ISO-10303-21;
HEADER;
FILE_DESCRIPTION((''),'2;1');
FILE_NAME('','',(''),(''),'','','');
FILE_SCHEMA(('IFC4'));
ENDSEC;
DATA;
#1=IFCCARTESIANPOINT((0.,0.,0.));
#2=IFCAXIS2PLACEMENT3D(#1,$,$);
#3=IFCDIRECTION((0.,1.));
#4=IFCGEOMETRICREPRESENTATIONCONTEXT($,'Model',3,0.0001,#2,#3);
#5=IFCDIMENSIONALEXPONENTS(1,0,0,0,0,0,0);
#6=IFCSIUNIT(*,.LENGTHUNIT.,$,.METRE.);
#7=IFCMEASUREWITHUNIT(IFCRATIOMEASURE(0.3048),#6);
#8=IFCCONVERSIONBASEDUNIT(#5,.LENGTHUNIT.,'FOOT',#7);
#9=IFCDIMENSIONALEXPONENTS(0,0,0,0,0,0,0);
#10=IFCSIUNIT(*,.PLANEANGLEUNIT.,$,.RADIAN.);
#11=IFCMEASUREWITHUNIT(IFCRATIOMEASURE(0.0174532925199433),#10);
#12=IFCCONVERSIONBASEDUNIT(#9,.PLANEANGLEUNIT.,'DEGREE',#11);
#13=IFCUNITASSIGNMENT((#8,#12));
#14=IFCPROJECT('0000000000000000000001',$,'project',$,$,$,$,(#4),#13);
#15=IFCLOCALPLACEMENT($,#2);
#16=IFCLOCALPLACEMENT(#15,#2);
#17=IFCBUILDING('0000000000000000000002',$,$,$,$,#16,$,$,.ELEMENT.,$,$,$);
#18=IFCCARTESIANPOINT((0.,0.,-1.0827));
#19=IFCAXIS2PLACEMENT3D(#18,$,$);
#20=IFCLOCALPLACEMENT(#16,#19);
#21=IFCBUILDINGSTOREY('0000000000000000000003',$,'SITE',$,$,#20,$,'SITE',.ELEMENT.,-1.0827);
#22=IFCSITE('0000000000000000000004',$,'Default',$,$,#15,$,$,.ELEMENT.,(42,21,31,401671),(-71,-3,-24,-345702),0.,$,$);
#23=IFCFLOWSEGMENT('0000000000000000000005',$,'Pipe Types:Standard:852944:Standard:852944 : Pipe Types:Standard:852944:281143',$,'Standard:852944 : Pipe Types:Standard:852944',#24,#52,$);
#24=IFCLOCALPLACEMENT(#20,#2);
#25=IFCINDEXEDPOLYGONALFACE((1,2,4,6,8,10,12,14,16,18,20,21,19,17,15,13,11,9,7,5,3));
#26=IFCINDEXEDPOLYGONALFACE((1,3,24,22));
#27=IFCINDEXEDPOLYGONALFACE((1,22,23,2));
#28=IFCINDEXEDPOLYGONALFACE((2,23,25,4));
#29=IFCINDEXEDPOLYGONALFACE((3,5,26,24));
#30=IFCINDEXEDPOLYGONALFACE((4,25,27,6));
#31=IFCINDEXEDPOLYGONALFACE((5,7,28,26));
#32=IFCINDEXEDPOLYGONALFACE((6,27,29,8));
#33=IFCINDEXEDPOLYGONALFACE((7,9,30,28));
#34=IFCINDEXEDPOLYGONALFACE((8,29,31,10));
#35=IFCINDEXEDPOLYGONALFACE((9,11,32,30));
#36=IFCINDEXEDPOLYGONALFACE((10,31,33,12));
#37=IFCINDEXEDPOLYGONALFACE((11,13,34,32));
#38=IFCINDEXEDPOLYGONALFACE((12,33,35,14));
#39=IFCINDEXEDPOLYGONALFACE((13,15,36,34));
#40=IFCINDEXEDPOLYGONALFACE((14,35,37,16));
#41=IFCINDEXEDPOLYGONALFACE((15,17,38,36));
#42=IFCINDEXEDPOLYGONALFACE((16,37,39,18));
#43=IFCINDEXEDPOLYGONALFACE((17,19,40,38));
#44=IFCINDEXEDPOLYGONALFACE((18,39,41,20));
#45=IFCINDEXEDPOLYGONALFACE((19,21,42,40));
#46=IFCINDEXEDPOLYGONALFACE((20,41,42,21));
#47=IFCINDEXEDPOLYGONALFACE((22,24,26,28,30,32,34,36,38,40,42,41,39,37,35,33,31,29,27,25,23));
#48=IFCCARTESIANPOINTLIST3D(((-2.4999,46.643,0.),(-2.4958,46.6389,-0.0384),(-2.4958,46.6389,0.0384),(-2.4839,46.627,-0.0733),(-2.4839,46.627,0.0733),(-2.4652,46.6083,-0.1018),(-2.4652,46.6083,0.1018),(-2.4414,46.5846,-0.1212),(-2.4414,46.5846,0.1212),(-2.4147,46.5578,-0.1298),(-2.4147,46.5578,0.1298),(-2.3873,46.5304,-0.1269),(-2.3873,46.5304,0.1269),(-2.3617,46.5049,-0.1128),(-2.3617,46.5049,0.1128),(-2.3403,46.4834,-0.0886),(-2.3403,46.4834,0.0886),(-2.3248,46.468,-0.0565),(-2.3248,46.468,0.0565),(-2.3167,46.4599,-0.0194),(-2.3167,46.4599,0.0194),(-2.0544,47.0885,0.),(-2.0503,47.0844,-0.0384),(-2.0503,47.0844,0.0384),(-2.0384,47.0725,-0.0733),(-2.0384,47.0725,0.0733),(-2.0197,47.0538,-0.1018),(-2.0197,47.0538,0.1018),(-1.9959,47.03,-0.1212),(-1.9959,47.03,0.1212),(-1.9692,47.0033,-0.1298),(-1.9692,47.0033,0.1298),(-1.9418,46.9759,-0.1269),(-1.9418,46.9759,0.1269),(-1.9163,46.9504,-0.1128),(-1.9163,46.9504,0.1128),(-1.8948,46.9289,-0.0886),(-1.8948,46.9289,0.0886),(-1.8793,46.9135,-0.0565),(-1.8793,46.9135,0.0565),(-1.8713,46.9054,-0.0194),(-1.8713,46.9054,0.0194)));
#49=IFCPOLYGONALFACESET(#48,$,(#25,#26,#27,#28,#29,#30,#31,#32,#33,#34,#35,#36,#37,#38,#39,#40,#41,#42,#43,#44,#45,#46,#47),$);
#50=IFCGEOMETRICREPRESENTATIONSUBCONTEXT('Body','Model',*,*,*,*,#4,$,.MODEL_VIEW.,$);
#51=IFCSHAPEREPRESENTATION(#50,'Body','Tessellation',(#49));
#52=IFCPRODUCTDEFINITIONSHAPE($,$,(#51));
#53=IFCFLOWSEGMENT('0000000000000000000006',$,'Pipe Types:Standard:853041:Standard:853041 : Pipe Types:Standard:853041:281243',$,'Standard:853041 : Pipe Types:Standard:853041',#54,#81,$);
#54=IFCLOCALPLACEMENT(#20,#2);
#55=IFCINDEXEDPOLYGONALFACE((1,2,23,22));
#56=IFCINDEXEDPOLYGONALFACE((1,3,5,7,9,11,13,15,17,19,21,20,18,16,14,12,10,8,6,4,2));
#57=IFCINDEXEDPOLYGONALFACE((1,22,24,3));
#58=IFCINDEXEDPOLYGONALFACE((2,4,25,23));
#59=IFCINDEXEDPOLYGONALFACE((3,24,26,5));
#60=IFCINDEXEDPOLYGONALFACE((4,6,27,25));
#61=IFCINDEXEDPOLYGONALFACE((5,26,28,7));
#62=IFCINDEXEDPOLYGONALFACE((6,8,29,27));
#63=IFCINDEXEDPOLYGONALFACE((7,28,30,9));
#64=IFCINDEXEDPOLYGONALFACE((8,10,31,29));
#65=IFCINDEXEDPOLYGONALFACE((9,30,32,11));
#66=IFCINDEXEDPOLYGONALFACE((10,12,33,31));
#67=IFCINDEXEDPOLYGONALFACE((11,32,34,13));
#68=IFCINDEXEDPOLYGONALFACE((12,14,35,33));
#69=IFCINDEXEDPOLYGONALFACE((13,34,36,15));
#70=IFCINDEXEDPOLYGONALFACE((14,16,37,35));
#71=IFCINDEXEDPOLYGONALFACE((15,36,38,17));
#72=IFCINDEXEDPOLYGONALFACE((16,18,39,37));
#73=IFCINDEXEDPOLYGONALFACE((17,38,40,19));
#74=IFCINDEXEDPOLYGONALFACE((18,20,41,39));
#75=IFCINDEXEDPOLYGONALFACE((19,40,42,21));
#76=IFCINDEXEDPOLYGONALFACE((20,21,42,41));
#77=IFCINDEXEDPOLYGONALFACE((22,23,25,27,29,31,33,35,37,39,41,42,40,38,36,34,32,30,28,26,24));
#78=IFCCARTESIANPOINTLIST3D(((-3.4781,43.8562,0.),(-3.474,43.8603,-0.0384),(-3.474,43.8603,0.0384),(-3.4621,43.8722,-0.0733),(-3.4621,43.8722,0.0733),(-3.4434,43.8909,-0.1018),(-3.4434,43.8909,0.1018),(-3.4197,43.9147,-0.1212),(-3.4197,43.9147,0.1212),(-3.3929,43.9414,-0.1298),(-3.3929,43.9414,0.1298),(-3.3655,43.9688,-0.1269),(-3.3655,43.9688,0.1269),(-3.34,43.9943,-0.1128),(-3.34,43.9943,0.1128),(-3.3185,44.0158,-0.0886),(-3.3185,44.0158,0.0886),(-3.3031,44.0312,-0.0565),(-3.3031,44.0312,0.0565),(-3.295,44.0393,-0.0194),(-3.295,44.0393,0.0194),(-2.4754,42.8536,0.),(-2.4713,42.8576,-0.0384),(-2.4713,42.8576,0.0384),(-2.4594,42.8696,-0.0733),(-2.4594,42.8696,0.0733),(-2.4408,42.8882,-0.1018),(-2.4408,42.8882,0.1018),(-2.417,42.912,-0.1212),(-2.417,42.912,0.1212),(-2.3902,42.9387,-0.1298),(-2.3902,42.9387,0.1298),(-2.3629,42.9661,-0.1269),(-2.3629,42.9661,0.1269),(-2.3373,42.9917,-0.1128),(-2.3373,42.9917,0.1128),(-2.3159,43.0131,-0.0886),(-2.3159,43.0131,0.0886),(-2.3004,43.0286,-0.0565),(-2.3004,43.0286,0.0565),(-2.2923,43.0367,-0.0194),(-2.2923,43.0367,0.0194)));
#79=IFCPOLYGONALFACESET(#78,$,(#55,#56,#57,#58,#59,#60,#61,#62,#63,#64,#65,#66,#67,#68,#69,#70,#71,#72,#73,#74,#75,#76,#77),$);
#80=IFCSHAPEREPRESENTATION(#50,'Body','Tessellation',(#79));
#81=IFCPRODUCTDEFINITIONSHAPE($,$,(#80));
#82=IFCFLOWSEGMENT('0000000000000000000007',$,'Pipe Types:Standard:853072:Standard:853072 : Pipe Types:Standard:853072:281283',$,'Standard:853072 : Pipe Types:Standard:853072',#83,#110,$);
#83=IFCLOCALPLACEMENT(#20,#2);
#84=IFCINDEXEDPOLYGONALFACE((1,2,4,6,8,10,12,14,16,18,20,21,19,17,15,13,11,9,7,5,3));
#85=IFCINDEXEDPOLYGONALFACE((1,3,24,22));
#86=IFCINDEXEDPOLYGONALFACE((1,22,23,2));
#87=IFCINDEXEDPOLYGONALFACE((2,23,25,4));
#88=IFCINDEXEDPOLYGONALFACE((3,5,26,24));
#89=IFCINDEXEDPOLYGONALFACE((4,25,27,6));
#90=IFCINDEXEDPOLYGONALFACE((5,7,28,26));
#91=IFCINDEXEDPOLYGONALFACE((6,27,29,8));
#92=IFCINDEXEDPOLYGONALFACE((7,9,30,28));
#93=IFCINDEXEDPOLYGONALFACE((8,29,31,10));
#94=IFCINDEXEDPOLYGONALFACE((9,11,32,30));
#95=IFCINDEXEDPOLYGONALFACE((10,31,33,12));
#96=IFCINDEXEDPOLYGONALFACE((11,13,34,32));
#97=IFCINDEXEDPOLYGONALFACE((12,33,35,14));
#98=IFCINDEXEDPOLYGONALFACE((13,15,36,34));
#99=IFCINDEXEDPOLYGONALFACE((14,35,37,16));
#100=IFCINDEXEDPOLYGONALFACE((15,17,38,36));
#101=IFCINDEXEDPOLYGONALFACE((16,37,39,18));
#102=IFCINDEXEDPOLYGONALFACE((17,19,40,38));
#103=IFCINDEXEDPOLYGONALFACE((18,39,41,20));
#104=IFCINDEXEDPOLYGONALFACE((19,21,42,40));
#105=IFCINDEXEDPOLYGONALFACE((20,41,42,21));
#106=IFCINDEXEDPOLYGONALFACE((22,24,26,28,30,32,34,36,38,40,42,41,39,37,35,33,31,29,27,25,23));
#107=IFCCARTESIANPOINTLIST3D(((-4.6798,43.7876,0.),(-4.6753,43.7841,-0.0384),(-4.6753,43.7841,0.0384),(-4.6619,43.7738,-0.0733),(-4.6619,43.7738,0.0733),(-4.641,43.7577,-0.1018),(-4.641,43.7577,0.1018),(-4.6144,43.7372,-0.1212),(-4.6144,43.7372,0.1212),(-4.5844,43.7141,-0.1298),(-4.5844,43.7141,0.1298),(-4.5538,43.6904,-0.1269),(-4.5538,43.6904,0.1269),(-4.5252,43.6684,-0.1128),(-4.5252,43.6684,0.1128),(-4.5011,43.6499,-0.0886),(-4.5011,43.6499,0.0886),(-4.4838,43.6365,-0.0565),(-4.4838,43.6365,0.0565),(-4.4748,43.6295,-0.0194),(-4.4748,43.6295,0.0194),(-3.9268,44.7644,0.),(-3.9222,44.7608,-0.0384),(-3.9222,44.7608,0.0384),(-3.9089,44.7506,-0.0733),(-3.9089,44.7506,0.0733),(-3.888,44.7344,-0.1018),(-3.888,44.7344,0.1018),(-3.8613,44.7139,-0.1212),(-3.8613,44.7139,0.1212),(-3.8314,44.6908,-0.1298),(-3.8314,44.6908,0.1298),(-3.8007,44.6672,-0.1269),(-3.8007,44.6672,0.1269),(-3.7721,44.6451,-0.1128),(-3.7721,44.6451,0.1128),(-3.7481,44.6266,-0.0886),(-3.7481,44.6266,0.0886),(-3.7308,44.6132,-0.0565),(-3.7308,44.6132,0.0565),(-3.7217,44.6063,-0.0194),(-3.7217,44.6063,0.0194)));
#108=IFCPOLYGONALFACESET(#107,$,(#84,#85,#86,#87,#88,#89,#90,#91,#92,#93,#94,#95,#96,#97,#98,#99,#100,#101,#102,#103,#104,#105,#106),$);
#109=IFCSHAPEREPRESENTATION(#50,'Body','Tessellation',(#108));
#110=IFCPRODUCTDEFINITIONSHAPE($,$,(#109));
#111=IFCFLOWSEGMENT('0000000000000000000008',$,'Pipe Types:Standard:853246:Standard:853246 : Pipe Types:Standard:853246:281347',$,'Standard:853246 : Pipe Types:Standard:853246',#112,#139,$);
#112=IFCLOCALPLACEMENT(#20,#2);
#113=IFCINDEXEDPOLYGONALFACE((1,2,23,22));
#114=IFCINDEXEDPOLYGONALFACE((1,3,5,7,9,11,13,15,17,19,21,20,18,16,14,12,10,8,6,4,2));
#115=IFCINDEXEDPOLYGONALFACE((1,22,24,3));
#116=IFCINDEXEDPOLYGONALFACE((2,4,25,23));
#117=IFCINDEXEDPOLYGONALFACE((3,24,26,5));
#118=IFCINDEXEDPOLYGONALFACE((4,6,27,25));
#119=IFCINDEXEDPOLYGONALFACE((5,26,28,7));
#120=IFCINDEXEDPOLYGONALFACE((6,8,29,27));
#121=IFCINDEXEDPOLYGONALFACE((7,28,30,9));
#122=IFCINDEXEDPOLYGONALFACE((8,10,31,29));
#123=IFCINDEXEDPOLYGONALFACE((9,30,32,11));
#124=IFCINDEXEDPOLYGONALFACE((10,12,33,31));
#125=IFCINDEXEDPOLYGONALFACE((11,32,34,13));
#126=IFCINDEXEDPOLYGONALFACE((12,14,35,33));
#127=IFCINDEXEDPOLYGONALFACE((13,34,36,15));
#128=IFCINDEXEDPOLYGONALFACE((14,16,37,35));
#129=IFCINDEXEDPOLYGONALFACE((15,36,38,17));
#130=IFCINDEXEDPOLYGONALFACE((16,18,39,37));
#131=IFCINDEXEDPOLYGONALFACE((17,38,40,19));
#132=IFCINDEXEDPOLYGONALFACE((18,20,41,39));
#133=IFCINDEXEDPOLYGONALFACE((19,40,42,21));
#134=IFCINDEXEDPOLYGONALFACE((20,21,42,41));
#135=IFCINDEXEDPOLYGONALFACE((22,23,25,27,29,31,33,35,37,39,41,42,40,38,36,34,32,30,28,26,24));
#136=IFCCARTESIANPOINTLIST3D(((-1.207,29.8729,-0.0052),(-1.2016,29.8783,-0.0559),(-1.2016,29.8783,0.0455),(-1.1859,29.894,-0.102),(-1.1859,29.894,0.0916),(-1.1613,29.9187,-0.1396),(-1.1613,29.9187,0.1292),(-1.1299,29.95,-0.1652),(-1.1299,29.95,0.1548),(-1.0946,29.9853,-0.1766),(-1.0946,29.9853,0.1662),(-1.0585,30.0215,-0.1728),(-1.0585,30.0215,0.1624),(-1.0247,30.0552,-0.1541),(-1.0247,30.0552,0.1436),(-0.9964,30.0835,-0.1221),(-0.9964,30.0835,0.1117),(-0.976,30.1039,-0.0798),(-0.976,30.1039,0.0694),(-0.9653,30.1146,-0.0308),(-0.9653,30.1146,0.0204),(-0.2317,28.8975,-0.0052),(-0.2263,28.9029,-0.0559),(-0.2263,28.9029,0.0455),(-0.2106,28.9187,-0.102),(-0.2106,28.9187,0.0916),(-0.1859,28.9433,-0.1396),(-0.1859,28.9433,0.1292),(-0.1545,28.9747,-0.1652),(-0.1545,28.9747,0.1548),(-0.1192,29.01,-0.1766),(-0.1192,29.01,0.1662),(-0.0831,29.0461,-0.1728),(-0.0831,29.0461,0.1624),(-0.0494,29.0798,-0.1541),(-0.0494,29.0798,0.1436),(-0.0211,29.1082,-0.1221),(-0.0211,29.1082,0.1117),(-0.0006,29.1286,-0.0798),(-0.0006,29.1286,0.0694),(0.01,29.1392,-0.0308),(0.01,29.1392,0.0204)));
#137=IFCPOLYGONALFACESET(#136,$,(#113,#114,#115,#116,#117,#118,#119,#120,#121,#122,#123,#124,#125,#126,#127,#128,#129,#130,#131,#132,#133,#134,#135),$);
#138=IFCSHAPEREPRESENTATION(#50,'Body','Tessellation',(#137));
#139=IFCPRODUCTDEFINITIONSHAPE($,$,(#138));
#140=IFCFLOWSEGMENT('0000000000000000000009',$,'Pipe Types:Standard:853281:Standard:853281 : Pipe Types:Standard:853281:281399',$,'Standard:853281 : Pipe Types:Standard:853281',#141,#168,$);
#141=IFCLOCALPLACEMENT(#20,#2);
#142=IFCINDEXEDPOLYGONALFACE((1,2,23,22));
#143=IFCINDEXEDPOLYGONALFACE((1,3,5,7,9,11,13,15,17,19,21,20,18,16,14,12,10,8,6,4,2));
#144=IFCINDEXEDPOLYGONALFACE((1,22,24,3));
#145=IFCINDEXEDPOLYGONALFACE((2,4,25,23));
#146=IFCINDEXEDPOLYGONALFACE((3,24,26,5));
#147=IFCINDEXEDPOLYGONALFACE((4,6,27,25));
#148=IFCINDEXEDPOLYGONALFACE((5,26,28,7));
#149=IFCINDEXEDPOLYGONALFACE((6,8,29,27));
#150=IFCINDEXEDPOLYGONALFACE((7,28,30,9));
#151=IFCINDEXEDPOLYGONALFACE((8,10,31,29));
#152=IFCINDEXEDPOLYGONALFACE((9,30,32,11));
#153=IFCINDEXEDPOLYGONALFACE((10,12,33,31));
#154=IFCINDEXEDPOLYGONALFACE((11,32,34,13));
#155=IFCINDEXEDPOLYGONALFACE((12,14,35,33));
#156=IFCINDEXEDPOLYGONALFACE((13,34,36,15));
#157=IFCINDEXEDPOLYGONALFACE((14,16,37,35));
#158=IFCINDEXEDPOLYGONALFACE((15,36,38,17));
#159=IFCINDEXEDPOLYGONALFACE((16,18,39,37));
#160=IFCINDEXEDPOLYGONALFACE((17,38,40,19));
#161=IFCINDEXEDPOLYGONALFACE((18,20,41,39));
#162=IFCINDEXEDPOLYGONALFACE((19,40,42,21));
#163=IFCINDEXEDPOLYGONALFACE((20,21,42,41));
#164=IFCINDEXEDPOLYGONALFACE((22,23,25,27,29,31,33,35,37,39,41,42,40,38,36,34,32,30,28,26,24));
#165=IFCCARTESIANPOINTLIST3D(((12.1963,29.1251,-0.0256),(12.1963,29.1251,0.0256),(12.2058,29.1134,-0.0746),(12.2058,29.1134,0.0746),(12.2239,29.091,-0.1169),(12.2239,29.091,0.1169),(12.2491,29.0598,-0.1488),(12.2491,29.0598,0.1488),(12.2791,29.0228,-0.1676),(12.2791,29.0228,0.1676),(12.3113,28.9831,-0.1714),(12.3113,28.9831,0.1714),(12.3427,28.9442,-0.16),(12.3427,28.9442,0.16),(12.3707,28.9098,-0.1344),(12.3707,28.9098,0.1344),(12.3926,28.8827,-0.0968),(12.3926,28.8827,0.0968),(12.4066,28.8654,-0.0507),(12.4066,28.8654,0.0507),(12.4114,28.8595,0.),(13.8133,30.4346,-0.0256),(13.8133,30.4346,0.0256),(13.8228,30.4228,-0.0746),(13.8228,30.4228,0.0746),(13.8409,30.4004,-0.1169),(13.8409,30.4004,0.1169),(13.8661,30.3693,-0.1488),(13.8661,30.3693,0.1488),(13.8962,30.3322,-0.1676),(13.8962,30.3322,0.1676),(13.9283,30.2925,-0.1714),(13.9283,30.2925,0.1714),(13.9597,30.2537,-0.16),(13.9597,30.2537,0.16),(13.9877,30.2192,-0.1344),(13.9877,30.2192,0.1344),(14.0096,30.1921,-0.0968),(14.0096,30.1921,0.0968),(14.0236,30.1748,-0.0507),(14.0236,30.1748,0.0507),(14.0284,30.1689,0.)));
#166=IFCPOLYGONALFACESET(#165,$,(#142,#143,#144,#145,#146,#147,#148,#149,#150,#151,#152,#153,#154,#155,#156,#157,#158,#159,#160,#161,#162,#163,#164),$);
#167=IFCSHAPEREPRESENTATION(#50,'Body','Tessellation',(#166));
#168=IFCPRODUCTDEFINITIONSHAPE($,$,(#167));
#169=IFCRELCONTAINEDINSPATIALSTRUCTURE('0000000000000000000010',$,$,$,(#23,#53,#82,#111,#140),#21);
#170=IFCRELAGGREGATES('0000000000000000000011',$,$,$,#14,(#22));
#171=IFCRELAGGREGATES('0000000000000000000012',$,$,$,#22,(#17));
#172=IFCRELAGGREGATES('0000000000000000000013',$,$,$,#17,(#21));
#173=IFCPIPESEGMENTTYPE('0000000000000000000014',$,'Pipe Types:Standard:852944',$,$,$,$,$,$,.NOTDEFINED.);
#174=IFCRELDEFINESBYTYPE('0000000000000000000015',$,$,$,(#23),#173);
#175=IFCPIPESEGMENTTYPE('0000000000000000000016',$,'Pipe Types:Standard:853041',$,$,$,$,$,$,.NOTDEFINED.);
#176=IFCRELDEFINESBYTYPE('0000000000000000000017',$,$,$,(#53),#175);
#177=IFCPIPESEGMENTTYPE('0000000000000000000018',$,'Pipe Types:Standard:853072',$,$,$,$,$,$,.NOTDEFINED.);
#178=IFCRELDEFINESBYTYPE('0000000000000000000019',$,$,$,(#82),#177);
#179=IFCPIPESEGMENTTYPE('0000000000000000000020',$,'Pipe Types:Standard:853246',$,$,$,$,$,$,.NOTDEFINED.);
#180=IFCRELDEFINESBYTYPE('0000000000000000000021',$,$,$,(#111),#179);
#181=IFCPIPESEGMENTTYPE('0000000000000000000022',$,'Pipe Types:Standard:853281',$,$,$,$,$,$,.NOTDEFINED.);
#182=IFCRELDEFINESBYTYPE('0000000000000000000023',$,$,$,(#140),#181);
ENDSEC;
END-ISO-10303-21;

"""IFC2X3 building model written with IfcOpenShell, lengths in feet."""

from ifc_helpers import new_model, entity, si_unit, converted_unit, direction, frame, frame_2d, origin, place, context, subcontext, project, spatial, circle, extrude, source, transform, mapped, type_object, type_shapes, element, save


model = new_model("IFC2X3")

# Units and contexts
model_context = context("Model", 3, precision=0.0001, world=origin(), true_north=direction((0.0, 1.0)))
body_context = subcontext(model_context, "Body", "Model", "MODEL_VIEW")
ifc_project = project(units=[converted_unit("LENGTHUNIT", "FOOT", entity("IfcRatioMeasure", 0.3048), si_unit("LENGTHUNIT", "METRE"), dimensions=[1, 0, 0, 0, 0, 0, 0]), converted_unit("PLANEANGLEUNIT", "DEGREE", entity("IfcRatioMeasure", 0.0174532925199433), si_unit("PLANEANGLEUNIT", "RADIAN"), dimensions=[0, 0, 0, 0, 0, 0, 0])], contexts=[model_context])

# Site, building, storey
site_placement = place(None, origin())
site = spatial("IfcSite", under=ifc_project, at=site_placement, Name="Default", CompositionType="ELEMENT", RefLatitude=(42, 21, 31, 401671), RefLongitude=(-71, -3, -24, -345702), RefElevation=0.0)
building_placement = place(site_placement, origin())
building = spatial("IfcBuilding", under=site, at=building_placement, CompositionType="ELEMENT")
storey_placement = place(building_placement, frame((0.0, 0.0, -1.0827)))
storey = spatial("IfcBuildingStorey", under=building, at=storey_placement, Name="SITE", LongName="SITE", CompositionType="ELEMENT", Elevation=-1.0827)

# Flow segments
pipe_segment_type_1 = type_object("IfcPipeSegmentType", Name="Pipe Types:Standard:852944", PredefinedType="NOTDEFINED")
shared_shape_1 = source(origin(), body_context, "Body", "SweptSolid", [
    extrude(circle(Radius=0.1302, at=frame_2d((0.0, 0.0), x_axis=(1.0, 0.0))), frame((-2.4078, 46.5509, -1.0827), z_axis=(0.707107, 0.707107, 0.0), x_axis=(-0.707107, 0.707107, 0.0)), (0.0, 0.0, 1.0), 0.63),
])
type_shapes(pipe_segment_type_1, [shared_shape_1])
flow_segment_1_placement = place(storey_placement, frame((0.0, 0.0, 1.0827)))
element("IfcFlowSegment", 1, at=flow_segment_1_placement, inside=storey, type_object=pipe_segment_type_1, Name="Pipe Types:Standard:852944:Standard:852944 : Pipe Types:Standard:852944:281143", ObjectType="Standard:852944 : Pipe Types:Standard:852944", context=body_context, shape_type="MappedRepresentation", body=[
    mapped(shared_shape_1, transform((0.0, 0.0, 0.0), scale=1.0)),
])
pipe_segment_type_2 = type_object("IfcPipeSegmentType", Name="Pipe Types:Standard:853041", PredefinedType="NOTDEFINED")
shared_shape_2 = source(origin(), body_context, "Body", "SweptSolid", [
    extrude(circle(Radius=0.1302, at=frame_2d((0.0, 0.0), x_axis=(1.0, 0.0))), frame((-3.386, 43.9483, -1.0827), z_axis=(0.707107, -0.707107, 0.0), x_axis=(-0.707107, -0.707107, 0.0)), (0.0, 0.0, 1.0), 1.418),
])
type_shapes(pipe_segment_type_2, [shared_shape_2])
flow_segment_2_placement = place(storey_placement, frame((0.0, 0.0, 1.0827)))
element("IfcFlowSegment", 2, at=flow_segment_2_placement, inside=storey, type_object=pipe_segment_type_2, Name="Pipe Types:Standard:853041:Standard:853041 : Pipe Types:Standard:853041:281243", ObjectType="Standard:853041 : Pipe Types:Standard:853041", context=body_context, shape_type="MappedRepresentation", body=[
    mapped(shared_shape_2, transform((0.0, 0.0, 0.0), scale=1.0)),
])
pipe_segment_type_3 = type_object("IfcPipeSegmentType", Name="Pipe Types:Standard:853072", PredefinedType="NOTDEFINED")
shared_shape_3 = source(origin(), body_context, "Body", "SweptSolid", [
    extrude(circle(Radius=0.1302, at=frame_2d((0.0, 0.0), x_axis=(1.0, 0.0))), frame((-4.5767, 43.7081, -1.0827), z_axis=(0.61059, 0.791947, 0.0), x_axis=(-0.791947, 0.61059, 0.0)), (0.0, 0.0, 1.0), 1.2333),
])
type_shapes(pipe_segment_type_3, [shared_shape_3])
flow_segment_3_placement = place(storey_placement, frame((0.0, 0.0, 1.0827)))
element("IfcFlowSegment", 3, at=flow_segment_3_placement, inside=storey, type_object=pipe_segment_type_3, Name="Pipe Types:Standard:853072:Standard:853072 : Pipe Types:Standard:853072:281283", ObjectType="Standard:853072 : Pipe Types:Standard:853072", context=body_context, shape_type="MappedRepresentation", body=[
    mapped(shared_shape_3, transform((0.0, 0.0, 0.0), scale=1.0)),
])
pipe_segment_type_4 = type_object("IfcPipeSegmentType", Name="Pipe Types:Standard:853246", PredefinedType="NOTDEFINED")
shared_shape_4 = source(origin(), body_context, "Body", "SweptSolid", [
    extrude(circle(Radius=0.1719, at=frame_2d((0.0, 0.0), x_axis=(1.0, 0.0))), frame((-0.1101, 29.0191, -1.0879), z_axis=(-0.707107, 0.707107, 0.0), x_axis=(-0.707107, -0.707107, 0.0)), (0.0, 0.0, 1.0), 1.3794),
])
type_shapes(pipe_segment_type_4, [shared_shape_4])
flow_segment_4_placement = place(storey_placement, frame((0.0, 0.0, 1.0827)))
element("IfcFlowSegment", 4, at=flow_segment_4_placement, inside=storey, type_object=pipe_segment_type_4, Name="Pipe Types:Standard:853246:Standard:853246 : Pipe Types:Standard:853246:281347", ObjectType="Standard:853246 : Pipe Types:Standard:853246", context=body_context, shape_type="MappedRepresentation", body=[
    mapped(shared_shape_4, transform((0.0, 0.0, 0.0), scale=1.0)),
])
pipe_segment_type_5 = type_object("IfcPipeSegmentType", Name="Pipe Types:Standard:853281", PredefinedType="NOTDEFINED")
shared_shape_5 = source(origin(), body_context, "Body", "SweptSolid", [
    extrude(circle(Radius=0.1719, at=frame_2d((0.0, 0.0), x_axis=(1.0, 0.0))), frame((12.3032, 28.993, -1.0827), z_axis=(0.777146, 0.62932, 0.0), x_axis=(0.62932, -0.777146, 0.0)), (0.0, 0.0, 1.0), 2.0807),
])
type_shapes(pipe_segment_type_5, [shared_shape_5])
flow_segment_5_placement = place(storey_placement, frame((0.0, 0.0, 1.0827)))
element("IfcFlowSegment", 5, at=flow_segment_5_placement, inside=storey, type_object=pipe_segment_type_5, Name="Pipe Types:Standard:853281:Standard:853281 : Pipe Types:Standard:853281:281399", ObjectType="Standard:853281 : Pipe Types:Standard:853281", context=body_context, shape_type="MappedRepresentation", body=[
    mapped(shared_shape_5, transform((0.0, 0.0, 0.0), scale=1.0)),
])

save(model, "model.ifc")
